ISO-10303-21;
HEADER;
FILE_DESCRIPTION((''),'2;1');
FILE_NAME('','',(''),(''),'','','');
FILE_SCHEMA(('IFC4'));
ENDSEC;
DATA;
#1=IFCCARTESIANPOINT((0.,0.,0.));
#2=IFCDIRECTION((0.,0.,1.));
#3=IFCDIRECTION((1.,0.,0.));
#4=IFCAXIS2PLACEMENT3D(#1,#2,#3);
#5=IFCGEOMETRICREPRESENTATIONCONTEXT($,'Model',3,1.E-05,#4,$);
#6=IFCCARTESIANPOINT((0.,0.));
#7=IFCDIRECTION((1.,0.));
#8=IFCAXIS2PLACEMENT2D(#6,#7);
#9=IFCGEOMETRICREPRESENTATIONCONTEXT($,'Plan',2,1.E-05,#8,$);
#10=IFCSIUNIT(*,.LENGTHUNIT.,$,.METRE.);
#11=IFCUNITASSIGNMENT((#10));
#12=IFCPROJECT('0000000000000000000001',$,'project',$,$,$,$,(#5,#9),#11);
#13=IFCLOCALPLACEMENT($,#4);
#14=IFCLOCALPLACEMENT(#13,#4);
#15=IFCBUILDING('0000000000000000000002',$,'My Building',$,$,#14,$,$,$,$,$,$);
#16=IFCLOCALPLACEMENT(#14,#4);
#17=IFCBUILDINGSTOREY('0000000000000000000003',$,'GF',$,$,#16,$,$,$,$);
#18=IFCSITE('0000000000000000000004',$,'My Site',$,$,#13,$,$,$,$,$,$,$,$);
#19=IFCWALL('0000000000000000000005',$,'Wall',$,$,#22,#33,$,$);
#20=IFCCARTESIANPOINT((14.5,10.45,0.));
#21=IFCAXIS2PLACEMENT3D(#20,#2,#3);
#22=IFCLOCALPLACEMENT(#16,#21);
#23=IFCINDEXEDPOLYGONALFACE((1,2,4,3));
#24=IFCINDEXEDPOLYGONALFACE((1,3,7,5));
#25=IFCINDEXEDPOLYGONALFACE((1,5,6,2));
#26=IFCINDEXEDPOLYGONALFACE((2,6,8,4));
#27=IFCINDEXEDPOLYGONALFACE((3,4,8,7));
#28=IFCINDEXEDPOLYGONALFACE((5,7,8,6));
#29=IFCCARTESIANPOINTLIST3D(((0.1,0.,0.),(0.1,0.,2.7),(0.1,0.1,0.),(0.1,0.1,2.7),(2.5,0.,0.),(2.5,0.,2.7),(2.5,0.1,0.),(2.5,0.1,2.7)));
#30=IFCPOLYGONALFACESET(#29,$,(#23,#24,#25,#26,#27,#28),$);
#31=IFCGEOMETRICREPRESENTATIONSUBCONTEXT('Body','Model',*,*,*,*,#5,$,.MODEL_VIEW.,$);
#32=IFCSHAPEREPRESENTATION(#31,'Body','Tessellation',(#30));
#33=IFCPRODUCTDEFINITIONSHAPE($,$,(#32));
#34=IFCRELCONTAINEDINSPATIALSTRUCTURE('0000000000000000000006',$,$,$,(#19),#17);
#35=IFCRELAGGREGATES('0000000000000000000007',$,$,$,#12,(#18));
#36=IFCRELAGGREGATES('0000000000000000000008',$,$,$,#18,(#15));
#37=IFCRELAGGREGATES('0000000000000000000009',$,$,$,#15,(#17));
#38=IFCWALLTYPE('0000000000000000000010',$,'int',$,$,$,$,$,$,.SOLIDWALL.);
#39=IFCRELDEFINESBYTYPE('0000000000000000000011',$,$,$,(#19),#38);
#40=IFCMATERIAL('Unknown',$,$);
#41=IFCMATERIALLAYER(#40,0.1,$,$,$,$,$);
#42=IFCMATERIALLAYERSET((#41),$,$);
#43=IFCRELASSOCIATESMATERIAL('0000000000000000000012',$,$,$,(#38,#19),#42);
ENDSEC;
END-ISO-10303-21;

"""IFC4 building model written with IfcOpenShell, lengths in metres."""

from ifc_helpers import new_model, si_unit, frame, origin_with_axes, origin_2d_with_axis, place, context, subcontext, project, spatial, line, indexed_curve, outline, extrude, material, layer, layer_set, layer_usage, type_object, element, save


model = new_model("IFC4")

# Units and contexts
model_context = context("Model", 3, precision=1e-05, world=origin_with_axes())
plan_context = context("Plan", 2, precision=1e-05, world=origin_2d_with_axis())
body_context_1 = subcontext(model_context, "Body", "Model", "MODEL_VIEW")
ifc_project = project(units=[si_unit("LENGTHUNIT", "METRE")], contexts=[model_context, plan_context])

# Site, building, storey
site_placement = place(None, origin_with_axes())
site = spatial("IfcSite", under=ifc_project, at=site_placement, Name="My Site")
building_placement = place(site_placement, origin_with_axes())
building = spatial("IfcBuilding", under=site, at=building_placement, Name="My Building")
storey_placement = place(building_placement, origin_with_axes())
storey = spatial("IfcBuildingStorey", under=building, at=storey_placement, Name="GF")

# Shared definitions
ifc_material = material(Name="Unknown")

# Shared definitions
ifc_layer_1 = layer(ifc_material, 0.1)
ifc_layer_set_1 = layer_set([ifc_layer_1])
wall_type_1 = type_object("IfcWallType", Name="int", PredefinedType="SOLIDWALL", material=ifc_layer_set_1)

# Wall
ifc_layer_usage_1 = layer_usage(ifc_layer_set_1, "AXIS2", "POSITIVE", 0.0)
wall_1_placement = place(storey_placement, frame((14.5, 10.45, 0.0), z_axis=(0.0, 0.0, 1.0), x_axis=(1.0, 0.0, 0.0)))
element("IfcWall", 1, at=wall_1_placement, inside=storey, type_object=wall_type_1, material=ifc_layer_usage_1, Name="Wall", context=body_context_1, shape_type="SweptSolid", body=[
    extrude(outline(indexed_curve([(0.1, 0.0), (0.1, 0.1), (2.5, 0.1), (2.5, 0.0)], segments=[line(1, 2, 3, 4, 1)])), origin_with_axes(), (0.0, 0.0, 1.0), 2.7),
])

save(model, "model.ifc")
